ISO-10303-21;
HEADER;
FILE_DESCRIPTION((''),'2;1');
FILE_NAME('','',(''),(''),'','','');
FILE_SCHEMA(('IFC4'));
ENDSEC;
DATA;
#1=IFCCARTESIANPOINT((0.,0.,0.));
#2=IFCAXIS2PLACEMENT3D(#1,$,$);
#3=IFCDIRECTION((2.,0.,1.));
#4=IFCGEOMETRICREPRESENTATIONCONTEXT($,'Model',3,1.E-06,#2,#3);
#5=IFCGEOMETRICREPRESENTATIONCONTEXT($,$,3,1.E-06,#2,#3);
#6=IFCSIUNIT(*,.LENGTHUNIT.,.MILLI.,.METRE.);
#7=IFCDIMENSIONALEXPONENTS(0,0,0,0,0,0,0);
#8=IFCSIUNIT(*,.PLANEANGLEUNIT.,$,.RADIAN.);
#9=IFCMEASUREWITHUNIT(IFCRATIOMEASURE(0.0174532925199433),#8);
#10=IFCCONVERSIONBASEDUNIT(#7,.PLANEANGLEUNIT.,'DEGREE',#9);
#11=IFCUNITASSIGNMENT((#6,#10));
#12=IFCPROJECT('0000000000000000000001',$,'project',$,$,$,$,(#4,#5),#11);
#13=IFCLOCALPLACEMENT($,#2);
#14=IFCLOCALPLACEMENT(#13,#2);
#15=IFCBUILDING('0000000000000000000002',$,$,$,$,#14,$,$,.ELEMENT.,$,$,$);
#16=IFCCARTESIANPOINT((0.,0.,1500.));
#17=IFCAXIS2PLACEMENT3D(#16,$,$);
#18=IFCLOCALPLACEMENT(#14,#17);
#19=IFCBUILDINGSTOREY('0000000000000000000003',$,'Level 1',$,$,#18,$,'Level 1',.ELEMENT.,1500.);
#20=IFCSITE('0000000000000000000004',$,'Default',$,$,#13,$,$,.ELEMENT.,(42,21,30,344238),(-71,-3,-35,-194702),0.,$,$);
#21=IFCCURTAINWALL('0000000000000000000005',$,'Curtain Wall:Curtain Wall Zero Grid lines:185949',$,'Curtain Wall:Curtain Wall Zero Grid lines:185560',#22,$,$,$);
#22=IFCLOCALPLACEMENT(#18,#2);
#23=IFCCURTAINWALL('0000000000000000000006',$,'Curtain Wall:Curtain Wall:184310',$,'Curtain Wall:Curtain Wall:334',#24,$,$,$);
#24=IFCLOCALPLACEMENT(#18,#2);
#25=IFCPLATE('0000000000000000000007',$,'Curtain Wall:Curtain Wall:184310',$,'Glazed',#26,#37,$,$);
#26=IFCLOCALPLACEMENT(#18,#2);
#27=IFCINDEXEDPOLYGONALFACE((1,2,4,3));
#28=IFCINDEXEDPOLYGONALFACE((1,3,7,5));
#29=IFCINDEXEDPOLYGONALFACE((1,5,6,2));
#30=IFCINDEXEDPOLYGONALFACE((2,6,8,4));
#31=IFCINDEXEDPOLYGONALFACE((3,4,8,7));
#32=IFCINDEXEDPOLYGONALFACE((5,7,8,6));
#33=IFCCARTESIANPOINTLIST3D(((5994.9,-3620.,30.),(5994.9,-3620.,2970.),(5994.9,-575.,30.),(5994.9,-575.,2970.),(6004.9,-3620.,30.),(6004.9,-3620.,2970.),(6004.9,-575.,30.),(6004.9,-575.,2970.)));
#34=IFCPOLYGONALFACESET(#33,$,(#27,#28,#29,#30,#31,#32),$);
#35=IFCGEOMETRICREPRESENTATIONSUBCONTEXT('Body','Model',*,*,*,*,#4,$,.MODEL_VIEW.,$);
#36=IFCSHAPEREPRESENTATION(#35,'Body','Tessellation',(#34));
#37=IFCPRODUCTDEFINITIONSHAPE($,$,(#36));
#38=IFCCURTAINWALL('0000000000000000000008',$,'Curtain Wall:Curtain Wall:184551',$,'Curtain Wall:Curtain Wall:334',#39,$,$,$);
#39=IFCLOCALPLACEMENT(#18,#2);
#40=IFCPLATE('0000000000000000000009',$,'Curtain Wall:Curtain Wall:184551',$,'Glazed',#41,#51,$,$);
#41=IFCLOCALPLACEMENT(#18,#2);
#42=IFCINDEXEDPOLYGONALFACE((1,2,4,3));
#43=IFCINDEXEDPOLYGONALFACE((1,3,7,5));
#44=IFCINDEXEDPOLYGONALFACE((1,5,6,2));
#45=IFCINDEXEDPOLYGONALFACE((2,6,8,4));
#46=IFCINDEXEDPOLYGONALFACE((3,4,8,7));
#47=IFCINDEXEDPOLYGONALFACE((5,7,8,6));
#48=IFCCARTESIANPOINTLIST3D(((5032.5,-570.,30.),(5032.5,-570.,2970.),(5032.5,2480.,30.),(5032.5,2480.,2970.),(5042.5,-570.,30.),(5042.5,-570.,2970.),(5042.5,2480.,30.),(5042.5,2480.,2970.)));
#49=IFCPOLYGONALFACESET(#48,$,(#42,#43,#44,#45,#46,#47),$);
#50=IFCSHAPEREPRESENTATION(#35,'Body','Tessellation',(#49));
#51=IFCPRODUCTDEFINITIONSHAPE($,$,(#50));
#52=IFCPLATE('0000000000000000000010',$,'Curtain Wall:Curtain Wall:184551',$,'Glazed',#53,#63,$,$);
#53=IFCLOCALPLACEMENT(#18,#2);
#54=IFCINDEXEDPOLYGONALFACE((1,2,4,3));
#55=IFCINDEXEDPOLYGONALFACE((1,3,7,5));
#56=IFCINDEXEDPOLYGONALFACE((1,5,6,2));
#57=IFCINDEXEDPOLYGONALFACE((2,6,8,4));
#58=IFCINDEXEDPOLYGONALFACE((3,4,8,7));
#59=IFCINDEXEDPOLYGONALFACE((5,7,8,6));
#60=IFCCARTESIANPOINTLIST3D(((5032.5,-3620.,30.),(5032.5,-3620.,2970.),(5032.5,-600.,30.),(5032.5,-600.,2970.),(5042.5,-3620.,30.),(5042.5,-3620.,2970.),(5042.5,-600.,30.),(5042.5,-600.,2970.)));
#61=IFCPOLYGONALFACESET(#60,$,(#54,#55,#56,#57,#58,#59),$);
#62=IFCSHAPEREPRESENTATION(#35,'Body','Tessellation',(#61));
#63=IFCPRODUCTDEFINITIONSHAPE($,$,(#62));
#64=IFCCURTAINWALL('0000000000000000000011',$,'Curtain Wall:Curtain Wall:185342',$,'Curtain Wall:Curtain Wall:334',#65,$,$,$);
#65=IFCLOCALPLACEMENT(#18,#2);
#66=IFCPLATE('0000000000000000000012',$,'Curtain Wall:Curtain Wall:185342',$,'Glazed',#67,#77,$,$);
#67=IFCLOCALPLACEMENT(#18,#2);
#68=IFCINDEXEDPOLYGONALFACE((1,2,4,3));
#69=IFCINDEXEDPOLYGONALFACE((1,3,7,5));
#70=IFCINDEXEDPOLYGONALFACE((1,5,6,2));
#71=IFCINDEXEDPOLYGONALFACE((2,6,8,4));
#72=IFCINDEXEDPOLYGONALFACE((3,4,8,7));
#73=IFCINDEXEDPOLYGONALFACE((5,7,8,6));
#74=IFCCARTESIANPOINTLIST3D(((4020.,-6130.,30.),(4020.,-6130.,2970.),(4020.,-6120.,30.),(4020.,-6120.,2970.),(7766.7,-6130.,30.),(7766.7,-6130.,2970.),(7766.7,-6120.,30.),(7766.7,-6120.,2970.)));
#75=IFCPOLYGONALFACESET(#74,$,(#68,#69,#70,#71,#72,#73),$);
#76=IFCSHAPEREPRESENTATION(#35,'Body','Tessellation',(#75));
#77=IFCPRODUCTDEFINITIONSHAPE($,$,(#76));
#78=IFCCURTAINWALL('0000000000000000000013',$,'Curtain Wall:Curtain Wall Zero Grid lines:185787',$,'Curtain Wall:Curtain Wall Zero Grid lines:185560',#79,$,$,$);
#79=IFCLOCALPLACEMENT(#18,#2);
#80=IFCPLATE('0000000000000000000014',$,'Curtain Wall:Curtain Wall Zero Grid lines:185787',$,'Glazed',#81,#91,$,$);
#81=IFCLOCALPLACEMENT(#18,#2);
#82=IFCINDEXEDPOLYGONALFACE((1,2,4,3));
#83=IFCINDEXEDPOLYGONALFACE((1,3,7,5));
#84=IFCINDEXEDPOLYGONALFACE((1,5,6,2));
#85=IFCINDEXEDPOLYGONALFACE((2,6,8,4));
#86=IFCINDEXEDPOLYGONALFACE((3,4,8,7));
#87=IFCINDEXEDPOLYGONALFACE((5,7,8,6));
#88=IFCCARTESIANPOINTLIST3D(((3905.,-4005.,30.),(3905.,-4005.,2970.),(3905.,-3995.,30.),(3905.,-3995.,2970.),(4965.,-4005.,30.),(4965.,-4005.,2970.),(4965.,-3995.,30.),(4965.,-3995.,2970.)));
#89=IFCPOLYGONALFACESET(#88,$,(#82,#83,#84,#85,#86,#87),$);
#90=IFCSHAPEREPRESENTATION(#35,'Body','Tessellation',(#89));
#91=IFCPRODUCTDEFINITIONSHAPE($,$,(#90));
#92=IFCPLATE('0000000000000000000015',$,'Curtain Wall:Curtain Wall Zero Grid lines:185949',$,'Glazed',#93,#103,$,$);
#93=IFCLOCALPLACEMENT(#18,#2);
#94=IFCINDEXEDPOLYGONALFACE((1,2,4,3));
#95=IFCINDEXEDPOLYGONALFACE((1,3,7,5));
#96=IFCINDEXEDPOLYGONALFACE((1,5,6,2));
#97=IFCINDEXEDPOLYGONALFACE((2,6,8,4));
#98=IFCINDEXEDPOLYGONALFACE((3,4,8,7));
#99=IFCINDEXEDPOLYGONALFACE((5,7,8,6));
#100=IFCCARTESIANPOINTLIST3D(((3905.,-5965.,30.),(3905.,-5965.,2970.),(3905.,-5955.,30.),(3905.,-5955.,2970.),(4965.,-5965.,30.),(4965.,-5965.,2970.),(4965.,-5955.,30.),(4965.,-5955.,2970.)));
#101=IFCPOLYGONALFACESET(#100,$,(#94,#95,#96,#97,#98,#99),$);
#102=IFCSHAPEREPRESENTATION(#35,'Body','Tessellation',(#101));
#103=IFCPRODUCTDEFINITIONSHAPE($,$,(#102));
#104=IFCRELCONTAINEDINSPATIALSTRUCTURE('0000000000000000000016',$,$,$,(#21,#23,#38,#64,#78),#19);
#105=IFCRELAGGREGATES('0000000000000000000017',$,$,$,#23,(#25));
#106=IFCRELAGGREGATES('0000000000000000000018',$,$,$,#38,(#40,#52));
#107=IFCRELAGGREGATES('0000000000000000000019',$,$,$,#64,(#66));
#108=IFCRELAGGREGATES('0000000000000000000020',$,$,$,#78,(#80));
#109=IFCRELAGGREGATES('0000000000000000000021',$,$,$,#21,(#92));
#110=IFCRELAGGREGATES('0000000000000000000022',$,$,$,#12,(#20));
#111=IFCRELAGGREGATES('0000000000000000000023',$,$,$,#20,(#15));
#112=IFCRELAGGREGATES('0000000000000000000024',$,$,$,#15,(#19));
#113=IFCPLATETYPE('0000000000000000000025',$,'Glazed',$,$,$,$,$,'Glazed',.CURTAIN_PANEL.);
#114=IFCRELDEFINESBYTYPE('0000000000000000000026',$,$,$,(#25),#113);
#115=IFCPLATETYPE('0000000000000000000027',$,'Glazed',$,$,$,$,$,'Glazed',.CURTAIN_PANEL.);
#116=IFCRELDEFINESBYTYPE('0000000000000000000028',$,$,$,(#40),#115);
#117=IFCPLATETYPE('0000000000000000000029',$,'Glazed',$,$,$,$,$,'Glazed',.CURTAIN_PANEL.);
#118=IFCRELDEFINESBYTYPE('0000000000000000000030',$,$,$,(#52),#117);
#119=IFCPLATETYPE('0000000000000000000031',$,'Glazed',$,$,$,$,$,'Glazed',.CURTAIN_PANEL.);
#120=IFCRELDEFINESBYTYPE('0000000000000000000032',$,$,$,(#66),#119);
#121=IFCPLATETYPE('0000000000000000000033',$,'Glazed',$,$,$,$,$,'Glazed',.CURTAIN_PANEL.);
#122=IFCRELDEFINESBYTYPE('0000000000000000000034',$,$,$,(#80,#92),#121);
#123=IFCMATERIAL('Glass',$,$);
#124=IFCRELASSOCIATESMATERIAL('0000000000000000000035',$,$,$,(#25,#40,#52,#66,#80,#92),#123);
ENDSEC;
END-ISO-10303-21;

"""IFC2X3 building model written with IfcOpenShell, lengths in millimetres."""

from ifc_helpers import new_model, entity, si_unit, converted_unit, direction, frame, origin, origin_2d_with_axis, place, context, subcontext, project, spatial, rectangle, extrude, source, transform, mapped, material, type_object, type_shapes, element, aggregate, save


model = new_model("IFC2X3")

# Units and contexts
model_context = context("Model", 3, precision=1e-06, world=origin(), true_north=direction((2.0, 0.0, 1.0)))
context_of_model = context(None, 3, precision=1e-06, world=origin(), true_north=direction((2.0, 0.0, 1.0)))
body_context = subcontext(model_context, "Body", "Model", "MODEL_VIEW")
ifc_project = project(units=[si_unit("LENGTHUNIT", "METRE", prefix="MILLI"), converted_unit("PLANEANGLEUNIT", "DEGREE", entity("IfcRatioMeasure", 0.0174532925199433), si_unit("PLANEANGLEUNIT", "RADIAN"), dimensions=[0, 0, 0, 0, 0, 0, 0])], contexts=[model_context, context_of_model])

# Site, building, storey
site_placement = place(None, origin())
site = spatial("IfcSite", under=ifc_project, at=site_placement, Name="Default", CompositionType="ELEMENT", RefLatitude=(42, 21, 30, 344238), RefLongitude=(-71, -3, -35, -194702), RefElevation=0.0)
building_placement = place(site_placement, origin())
building = spatial("IfcBuilding", under=site, at=building_placement, CompositionType="ELEMENT")
storey_placement = place(building_placement, frame((0.0, 0.0, 1500.0)))
storey = spatial("IfcBuildingStorey", under=building, at=storey_placement, Name="Level 1", LongName="Level 1", CompositionType="ELEMENT", Elevation=1500.0)

# Curtain wall
curtain_wall_1_placement = place(storey_placement, origin())
curtain_wall_1 = element("IfcCurtainWall", 1, at=curtain_wall_1_placement, inside=storey, Name="Curtain Wall:Curtain Wall Zero Grid lines:185949", ObjectType="Curtain Wall:Curtain Wall Zero Grid lines:185560")

# Curtain walls, plates
ifc_material = material(Name="Glass")
curtain_wall_2_placement = place(storey_placement, origin())
curtain_wall_2 = element("IfcCurtainWall", 2, at=curtain_wall_2_placement, inside=storey, Name="Curtain Wall:Curtain Wall:184310", ObjectType="Curtain Wall:Curtain Wall:334")
plate_type_1 = type_object("IfcPlateType", Name="Glazed", ElementType="Glazed", PredefinedType="CURTAIN_PANEL")
shared_shape_1 = source(origin(), body_context, "Body", "SweptSolid", [
    extrude(rectangle(XDim=10.0, YDim=3045.0, at=origin_2d_with_axis()), frame((0.0, 0.0, 0.0), z_axis=(0.0, 0.0, 1.0), x_axis=(0.0, 1.0, 0.0)), (0.0, 0.0, 1.0), 2940.0),
])
type_shapes(plate_type_1, [shared_shape_1])
plate_1_placement = place(storey_placement, frame((5999.9, -2097.5, 30.0), z_axis=(0.0, 0.0, 1.0), x_axis=(0.0, -1.0, 0.0)))
plate_1 = element("IfcPlate", 3, at=plate_1_placement, type_object=plate_type_1, material=ifc_material, Name="Curtain Wall:Curtain Wall:184310", ObjectType="Glazed", context=body_context, shape_type="MappedRepresentation", body=[
    mapped(shared_shape_1, transform((0.0, 0.0, 0.0), scale=1.0)),
])
aggregate(curtain_wall_2, [plate_1])
curtain_wall_3_placement = place(storey_placement, origin())
curtain_wall_3 = element("IfcCurtainWall", 4, at=curtain_wall_3_placement, inside=storey, Name="Curtain Wall:Curtain Wall:184551", ObjectType="Curtain Wall:Curtain Wall:334")
plate_type_2 = type_object("IfcPlateType", Name="Glazed", ElementType="Glazed", PredefinedType="CURTAIN_PANEL")
shared_shape_2 = source(origin(), body_context, "Body", "SweptSolid", [
    extrude(rectangle(XDim=10.0, YDim=3050.0, at=origin_2d_with_axis()), frame((0.0, 0.0, 0.0), z_axis=(0.0, 0.0, 1.0), x_axis=(0.0, 1.0, 0.0)), (0.0, 0.0, 1.0), 2940.0),
])
type_shapes(plate_type_2, [shared_shape_2])
plate_2_placement = place(storey_placement, frame((5037.5, 955.0, 30.0), z_axis=(0.0, 0.0, 1.0), x_axis=(0.0, -1.0, 0.0)))
plate_2 = element("IfcPlate", 5, at=plate_2_placement, type_object=plate_type_2, material=ifc_material, Name="Curtain Wall:Curtain Wall:184551", ObjectType="Glazed", context=body_context, shape_type="MappedRepresentation", body=[
    mapped(shared_shape_2, transform((0.0, 0.0, 0.0), scale=1.0)),
])
plate_type_3 = type_object("IfcPlateType", Name="Glazed", ElementType="Glazed", PredefinedType="CURTAIN_PANEL")
shared_shape_3 = source(origin(), body_context, "Body", "SweptSolid", [
    extrude(rectangle(XDim=10.0, YDim=3020.0, at=origin_2d_with_axis()), frame((0.0, 0.0, 0.0), z_axis=(0.0, 0.0, 1.0), x_axis=(0.0, 1.0, 0.0)), (0.0, 0.0, 1.0), 2940.0),
])
type_shapes(plate_type_3, [shared_shape_3])
plate_3_placement = place(storey_placement, frame((5037.5, -2110.0, 30.0), z_axis=(0.0, 0.0, 1.0), x_axis=(0.0, -1.0, 0.0)))
plate_3 = element("IfcPlate", 6, at=plate_3_placement, type_object=plate_type_3, material=ifc_material, Name="Curtain Wall:Curtain Wall:184551", ObjectType="Glazed", context=body_context, shape_type="MappedRepresentation", body=[
    mapped(shared_shape_3, transform((0.0, 0.0, 0.0), scale=1.0)),
])
aggregate(curtain_wall_3, [plate_2, plate_3])

# Curtain walls, plates
curtain_wall_4_placement = place(storey_placement, origin())
curtain_wall_4 = element("IfcCurtainWall", 7, at=curtain_wall_4_placement, inside=storey, Name="Curtain Wall:Curtain Wall:185342", ObjectType="Curtain Wall:Curtain Wall:334")
plate_type_4 = type_object("IfcPlateType", Name="Glazed", ElementType="Glazed", PredefinedType="CURTAIN_PANEL")
shared_shape_4 = source(origin(), body_context, "Body", "SweptSolid", [
    extrude(rectangle(XDim=10.0, YDim=3746.7, at=origin_2d_with_axis()), frame((0.0, 0.0, 0.0), z_axis=(0.0, 0.0, 1.0), x_axis=(0.0, 1.0, 0.0)), (0.0, 0.0, 1.0), 2940.0),
])
type_shapes(plate_type_4, [shared_shape_4])
plate_4_placement = place(storey_placement, frame((5893.3, -6125.0, 30.0), z_axis=(0.0, 0.0, 1.0), x_axis=(-1.0, 0.0, 0.0)))
plate_4 = element("IfcPlate", 8, at=plate_4_placement, type_object=plate_type_4, material=ifc_material, Name="Curtain Wall:Curtain Wall:185342", ObjectType="Glazed", context=body_context, shape_type="MappedRepresentation", body=[
    mapped(shared_shape_4, transform((0.0, 0.0, 0.0), scale=1.0)),
])
aggregate(curtain_wall_4, [plate_4])
curtain_wall_5_placement = place(storey_placement, origin())
curtain_wall_5 = element("IfcCurtainWall", 9, at=curtain_wall_5_placement, inside=storey, Name="Curtain Wall:Curtain Wall Zero Grid lines:185787", ObjectType="Curtain Wall:Curtain Wall Zero Grid lines:185560")
plate_type_5 = type_object("IfcPlateType", Name="Glazed", ElementType="Glazed", PredefinedType="CURTAIN_PANEL")
shared_shape_5 = source(origin(), body_context, "Body", "SweptSolid", [
    extrude(rectangle(XDim=10.0, YDim=1060.0, at=origin_2d_with_axis()), frame((0.0, 0.0, 0.0), z_axis=(0.0, 0.0, 1.0), x_axis=(0.0, 1.0, 0.0)), (0.0, 0.0, 1.0), 2940.0),
])
type_shapes(plate_type_5, [shared_shape_5])
plate_5_placement = place(storey_placement, frame((4435.0, -4000.0, 30.0)))
plate_5 = element("IfcPlate", 10, at=plate_5_placement, type_object=plate_type_5, material=ifc_material, Name="Curtain Wall:Curtain Wall Zero Grid lines:185787", ObjectType="Glazed", context=body_context, shape_type="MappedRepresentation", body=[
    mapped(shared_shape_5, transform((0.0, 0.0, 0.0), scale=1.0)),
])
aggregate(curtain_wall_5, [plate_5])

# Plate
plate_6_placement = place(storey_placement, frame((4435.0, -5960.0, 30.0)))
plate_6 = element("IfcPlate", 11, at=plate_6_placement, type_object=plate_type_5, material=ifc_material, Name="Curtain Wall:Curtain Wall Zero Grid lines:185949", ObjectType="Glazed", context=body_context, shape_type="MappedRepresentation", body=[
    mapped(shared_shape_5, transform((0.0, 0.0, 0.0), scale=1.0)),
])
aggregate(curtain_wall_1, [plate_6])

save(model, "model.ifc")
